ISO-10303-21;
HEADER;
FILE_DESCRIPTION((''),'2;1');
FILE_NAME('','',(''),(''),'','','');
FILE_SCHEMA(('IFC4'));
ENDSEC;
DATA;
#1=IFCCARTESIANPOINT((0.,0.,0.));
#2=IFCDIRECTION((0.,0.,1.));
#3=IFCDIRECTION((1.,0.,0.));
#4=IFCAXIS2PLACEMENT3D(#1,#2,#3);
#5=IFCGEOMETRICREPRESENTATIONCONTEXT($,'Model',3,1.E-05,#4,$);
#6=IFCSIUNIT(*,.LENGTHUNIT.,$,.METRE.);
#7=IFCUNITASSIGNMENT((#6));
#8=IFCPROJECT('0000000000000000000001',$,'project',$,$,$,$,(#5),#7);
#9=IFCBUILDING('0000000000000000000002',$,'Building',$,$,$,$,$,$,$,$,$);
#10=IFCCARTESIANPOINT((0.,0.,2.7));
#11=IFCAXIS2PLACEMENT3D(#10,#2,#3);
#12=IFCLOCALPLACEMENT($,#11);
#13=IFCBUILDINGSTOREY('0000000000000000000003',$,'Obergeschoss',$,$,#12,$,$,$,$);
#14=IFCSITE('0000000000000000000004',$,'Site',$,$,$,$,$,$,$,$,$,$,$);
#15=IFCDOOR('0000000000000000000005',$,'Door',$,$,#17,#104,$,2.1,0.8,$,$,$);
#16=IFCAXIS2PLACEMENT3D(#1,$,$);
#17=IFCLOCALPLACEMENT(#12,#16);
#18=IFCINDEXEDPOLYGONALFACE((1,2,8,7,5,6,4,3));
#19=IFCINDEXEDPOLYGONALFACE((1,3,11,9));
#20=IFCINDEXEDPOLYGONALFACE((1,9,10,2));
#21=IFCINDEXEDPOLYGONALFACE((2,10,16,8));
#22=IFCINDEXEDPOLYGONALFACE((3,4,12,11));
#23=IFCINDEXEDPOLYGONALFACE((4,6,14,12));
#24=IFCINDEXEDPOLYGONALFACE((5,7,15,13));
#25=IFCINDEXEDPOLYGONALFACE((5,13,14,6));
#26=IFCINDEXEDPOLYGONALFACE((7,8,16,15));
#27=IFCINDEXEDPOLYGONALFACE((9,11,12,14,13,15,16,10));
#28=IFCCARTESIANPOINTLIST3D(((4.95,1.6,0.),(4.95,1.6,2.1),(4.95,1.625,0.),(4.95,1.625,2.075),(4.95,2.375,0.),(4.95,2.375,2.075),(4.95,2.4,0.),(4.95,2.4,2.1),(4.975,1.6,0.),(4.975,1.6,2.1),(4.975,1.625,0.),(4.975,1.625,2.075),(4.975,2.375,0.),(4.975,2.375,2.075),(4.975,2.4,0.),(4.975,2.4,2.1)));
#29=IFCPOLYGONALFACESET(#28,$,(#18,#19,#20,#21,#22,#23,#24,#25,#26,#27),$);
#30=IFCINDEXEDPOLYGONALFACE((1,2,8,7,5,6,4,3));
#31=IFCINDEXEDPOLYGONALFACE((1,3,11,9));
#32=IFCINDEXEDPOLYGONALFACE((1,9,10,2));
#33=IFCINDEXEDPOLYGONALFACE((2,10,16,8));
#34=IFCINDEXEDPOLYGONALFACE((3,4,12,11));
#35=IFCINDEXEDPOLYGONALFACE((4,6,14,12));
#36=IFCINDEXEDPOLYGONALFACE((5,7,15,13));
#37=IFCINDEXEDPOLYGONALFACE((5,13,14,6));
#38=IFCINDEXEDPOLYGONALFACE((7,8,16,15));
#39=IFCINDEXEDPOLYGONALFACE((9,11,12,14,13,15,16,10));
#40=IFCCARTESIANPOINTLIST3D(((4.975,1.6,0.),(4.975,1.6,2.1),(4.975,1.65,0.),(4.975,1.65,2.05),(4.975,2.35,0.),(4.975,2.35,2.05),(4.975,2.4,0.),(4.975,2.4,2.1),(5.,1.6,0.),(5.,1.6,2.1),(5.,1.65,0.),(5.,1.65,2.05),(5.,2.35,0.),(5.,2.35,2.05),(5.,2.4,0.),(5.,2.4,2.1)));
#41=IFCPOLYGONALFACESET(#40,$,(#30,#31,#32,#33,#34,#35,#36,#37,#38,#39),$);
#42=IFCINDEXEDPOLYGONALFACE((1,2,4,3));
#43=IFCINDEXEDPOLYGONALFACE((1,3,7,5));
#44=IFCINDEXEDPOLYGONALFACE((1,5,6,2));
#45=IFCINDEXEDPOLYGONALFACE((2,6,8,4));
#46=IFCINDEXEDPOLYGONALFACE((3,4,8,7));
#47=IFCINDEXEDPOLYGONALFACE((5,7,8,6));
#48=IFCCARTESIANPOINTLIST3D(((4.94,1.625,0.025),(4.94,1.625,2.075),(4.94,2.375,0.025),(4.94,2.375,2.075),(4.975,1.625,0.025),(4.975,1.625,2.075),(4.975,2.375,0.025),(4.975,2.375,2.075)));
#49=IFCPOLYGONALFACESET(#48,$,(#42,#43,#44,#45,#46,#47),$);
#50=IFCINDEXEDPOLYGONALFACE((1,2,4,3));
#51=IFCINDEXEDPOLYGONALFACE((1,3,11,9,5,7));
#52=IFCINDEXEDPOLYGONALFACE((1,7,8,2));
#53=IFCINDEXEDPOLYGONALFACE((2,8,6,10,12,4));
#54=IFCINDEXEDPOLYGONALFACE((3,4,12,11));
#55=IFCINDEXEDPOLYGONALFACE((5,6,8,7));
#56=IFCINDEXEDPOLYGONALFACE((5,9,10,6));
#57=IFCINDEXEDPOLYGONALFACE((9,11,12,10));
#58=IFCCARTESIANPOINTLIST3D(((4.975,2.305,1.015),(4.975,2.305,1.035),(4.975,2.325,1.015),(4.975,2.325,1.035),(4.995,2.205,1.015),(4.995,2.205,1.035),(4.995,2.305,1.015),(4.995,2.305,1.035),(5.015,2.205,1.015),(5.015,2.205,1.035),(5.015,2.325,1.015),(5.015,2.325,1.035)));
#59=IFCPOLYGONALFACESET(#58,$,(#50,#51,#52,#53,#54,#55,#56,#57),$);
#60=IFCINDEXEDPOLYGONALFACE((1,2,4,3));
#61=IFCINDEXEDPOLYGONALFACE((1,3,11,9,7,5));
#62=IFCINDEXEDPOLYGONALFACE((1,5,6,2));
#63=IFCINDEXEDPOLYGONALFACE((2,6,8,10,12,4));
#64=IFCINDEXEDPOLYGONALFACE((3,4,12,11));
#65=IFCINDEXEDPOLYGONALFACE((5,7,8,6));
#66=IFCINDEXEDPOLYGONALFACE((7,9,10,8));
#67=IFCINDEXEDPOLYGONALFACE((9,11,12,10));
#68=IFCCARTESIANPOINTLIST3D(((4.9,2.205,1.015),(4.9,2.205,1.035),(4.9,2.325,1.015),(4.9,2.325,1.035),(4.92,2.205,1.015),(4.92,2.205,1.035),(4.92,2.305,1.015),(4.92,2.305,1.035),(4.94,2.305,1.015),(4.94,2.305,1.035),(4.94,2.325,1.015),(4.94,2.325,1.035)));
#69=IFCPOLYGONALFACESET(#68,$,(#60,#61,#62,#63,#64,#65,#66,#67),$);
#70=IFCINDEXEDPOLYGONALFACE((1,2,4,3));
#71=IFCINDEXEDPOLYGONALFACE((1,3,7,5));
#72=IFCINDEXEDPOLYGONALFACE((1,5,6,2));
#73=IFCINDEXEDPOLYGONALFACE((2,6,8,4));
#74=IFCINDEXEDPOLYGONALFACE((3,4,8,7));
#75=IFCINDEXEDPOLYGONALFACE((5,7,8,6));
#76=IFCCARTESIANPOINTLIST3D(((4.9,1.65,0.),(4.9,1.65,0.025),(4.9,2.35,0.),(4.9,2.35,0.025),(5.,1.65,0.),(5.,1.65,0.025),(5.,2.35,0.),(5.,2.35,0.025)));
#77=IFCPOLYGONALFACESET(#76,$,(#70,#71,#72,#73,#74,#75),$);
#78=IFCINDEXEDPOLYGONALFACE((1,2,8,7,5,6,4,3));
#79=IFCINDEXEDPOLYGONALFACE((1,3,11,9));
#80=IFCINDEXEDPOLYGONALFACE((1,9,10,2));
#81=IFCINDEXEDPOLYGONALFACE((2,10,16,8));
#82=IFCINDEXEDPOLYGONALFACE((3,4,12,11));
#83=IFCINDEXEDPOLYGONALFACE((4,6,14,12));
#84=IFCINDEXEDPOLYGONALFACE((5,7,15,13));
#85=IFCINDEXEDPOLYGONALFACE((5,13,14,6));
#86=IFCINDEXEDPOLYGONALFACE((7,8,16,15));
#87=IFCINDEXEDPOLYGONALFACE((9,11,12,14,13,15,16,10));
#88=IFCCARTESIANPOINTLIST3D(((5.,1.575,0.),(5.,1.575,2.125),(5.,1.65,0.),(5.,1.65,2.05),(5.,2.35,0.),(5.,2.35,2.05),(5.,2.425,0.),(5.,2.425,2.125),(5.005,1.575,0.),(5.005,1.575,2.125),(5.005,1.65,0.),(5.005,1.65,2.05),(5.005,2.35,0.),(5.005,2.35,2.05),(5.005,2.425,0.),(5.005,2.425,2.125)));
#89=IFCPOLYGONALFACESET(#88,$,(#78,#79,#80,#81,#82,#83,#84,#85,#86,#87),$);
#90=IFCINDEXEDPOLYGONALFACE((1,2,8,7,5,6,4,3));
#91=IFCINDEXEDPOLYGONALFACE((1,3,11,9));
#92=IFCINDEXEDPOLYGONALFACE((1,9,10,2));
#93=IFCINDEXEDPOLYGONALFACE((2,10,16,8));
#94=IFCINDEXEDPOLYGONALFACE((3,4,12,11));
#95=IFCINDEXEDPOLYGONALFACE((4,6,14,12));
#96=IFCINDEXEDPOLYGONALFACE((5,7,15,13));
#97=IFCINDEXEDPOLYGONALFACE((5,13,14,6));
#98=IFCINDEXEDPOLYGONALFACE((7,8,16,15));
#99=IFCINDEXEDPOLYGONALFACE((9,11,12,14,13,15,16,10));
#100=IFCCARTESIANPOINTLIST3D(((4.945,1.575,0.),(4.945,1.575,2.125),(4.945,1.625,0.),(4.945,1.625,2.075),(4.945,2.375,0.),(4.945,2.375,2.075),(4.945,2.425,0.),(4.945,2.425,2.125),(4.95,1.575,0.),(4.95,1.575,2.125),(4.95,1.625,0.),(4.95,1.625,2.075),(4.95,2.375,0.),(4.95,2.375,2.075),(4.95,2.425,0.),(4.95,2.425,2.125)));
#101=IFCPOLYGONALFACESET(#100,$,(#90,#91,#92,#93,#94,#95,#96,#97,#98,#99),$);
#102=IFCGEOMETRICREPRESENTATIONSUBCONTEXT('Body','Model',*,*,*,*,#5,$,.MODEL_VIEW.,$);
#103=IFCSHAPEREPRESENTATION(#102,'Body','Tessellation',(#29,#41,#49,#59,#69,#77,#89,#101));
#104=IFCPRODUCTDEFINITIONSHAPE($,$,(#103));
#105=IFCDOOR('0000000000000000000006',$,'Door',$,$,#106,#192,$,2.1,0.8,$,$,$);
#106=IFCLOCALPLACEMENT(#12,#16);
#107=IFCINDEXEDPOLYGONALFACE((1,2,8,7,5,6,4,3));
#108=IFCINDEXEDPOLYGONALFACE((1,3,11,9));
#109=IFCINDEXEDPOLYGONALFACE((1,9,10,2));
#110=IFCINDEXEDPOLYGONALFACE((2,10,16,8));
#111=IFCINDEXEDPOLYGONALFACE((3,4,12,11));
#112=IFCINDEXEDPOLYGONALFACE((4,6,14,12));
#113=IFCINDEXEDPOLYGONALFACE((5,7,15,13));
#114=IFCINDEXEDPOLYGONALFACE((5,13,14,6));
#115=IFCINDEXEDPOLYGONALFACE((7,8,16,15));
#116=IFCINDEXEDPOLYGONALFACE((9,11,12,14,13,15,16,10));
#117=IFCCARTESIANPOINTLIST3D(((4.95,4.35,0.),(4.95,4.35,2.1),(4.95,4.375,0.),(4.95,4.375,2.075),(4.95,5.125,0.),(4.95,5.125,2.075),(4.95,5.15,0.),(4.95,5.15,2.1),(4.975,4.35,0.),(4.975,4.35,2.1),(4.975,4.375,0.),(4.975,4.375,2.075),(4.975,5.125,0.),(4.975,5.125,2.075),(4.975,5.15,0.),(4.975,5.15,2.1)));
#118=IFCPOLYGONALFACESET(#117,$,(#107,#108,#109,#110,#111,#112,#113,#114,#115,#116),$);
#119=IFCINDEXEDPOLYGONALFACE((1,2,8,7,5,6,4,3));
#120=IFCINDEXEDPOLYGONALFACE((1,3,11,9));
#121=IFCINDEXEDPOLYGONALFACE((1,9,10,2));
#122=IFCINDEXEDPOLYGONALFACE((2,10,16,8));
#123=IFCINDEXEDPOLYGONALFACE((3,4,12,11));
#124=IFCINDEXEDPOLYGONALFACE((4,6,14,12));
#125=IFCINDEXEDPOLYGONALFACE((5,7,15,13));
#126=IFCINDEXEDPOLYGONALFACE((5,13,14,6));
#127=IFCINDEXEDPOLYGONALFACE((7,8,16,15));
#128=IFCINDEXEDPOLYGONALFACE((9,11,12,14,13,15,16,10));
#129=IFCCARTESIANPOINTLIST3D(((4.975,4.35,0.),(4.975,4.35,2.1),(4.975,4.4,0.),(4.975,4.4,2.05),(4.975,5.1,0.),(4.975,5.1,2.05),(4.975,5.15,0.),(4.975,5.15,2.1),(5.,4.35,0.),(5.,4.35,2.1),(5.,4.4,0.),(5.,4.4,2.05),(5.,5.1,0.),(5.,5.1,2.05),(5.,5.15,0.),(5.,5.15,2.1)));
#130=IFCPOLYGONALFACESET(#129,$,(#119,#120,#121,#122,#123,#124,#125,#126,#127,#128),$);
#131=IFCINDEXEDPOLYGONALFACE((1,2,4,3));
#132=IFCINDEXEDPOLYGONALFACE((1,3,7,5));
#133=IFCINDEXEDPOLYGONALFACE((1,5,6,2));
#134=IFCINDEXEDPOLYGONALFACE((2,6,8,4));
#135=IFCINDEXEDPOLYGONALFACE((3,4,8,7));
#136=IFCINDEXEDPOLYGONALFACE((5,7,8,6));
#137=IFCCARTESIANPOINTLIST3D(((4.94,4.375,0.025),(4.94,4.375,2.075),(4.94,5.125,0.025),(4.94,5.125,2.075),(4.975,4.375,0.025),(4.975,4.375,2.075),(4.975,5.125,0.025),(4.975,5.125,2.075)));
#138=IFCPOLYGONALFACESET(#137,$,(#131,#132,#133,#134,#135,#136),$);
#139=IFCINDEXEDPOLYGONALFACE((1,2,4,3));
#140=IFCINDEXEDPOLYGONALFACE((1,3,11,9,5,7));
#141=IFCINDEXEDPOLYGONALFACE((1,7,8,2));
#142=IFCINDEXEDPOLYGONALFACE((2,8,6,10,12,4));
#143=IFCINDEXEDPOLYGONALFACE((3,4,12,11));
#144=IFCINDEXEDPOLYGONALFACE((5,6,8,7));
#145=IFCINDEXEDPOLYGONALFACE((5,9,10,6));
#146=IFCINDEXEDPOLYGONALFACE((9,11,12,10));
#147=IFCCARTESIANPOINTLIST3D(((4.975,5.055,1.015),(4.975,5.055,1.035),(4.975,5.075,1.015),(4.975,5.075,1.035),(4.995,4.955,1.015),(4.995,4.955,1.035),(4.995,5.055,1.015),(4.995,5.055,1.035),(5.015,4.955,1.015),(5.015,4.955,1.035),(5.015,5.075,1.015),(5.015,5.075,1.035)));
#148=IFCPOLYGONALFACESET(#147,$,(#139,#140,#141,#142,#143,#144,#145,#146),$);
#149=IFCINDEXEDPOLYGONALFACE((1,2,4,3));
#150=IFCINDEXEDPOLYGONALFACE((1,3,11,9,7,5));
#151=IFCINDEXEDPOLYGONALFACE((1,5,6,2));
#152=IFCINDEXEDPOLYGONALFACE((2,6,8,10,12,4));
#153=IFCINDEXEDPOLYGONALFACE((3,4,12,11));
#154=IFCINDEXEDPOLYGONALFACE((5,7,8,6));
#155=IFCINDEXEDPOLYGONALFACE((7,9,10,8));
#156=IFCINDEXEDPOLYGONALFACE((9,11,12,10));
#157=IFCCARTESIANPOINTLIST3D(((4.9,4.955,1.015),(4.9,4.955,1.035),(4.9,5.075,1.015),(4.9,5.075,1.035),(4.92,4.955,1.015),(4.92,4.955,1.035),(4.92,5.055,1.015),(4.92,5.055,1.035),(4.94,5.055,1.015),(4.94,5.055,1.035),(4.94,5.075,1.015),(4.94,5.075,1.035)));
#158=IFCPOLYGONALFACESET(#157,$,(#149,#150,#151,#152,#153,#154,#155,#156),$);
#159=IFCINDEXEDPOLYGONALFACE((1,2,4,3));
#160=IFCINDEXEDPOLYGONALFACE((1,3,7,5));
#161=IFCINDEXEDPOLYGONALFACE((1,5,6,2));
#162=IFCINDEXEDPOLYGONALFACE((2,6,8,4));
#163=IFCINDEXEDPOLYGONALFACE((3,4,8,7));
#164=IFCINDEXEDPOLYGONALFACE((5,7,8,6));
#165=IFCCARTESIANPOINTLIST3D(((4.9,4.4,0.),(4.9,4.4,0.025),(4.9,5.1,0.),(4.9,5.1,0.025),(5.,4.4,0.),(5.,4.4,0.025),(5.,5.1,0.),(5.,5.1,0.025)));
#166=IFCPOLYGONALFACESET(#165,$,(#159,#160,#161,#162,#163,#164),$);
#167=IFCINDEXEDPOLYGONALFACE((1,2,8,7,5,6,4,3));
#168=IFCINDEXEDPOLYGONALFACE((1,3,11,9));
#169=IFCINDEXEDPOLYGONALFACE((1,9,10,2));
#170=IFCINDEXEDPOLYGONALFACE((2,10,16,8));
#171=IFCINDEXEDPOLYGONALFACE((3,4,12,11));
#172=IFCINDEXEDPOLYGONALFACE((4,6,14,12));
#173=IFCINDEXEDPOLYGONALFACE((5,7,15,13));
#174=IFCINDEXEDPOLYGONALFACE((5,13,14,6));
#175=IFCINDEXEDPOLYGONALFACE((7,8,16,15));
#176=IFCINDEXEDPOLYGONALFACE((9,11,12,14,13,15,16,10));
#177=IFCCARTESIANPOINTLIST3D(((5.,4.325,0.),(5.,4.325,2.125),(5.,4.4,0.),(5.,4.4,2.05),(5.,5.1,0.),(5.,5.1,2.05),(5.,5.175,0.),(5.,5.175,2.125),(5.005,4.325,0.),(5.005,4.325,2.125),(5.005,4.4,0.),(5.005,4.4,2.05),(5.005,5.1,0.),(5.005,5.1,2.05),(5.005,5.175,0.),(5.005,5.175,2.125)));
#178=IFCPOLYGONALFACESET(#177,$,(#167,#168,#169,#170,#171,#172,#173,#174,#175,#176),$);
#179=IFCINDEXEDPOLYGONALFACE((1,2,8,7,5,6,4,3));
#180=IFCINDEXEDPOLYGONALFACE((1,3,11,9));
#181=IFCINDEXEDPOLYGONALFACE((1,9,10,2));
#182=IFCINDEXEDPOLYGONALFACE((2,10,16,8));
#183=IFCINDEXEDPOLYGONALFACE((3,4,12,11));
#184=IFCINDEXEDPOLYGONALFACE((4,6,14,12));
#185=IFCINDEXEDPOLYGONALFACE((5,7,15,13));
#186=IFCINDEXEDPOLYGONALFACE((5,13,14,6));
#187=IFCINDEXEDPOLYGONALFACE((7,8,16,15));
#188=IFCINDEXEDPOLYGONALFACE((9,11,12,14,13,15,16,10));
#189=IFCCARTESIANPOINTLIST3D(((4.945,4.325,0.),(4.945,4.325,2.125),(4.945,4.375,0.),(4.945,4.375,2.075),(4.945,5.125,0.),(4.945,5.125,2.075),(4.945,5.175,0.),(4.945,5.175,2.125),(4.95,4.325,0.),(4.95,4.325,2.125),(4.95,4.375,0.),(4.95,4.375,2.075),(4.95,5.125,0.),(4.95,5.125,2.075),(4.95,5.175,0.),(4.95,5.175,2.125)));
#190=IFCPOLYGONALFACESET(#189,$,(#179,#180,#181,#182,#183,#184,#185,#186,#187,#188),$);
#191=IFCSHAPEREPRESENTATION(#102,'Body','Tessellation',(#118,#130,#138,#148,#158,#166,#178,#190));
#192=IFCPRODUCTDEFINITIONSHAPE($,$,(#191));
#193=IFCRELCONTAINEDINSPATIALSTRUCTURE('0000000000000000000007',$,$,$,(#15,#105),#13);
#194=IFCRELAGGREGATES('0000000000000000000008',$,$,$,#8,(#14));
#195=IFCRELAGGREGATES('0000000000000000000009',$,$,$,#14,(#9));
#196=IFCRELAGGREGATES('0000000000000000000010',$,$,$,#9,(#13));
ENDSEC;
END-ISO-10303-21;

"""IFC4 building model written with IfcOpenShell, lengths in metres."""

from ifc_helpers import new_model, si_unit, frame, origin_with_axes, place, context, subcontext, project, spatial, line, indexed_curve, outline, extrude, element, save


model = new_model("IFC4")

# Units and contexts
model_context = context("Model", 3, precision=1e-05, world=origin_with_axes())
body_context = subcontext(model_context, "Body", "Model", "MODEL_VIEW")
ifc_project = project(units=[si_unit("LENGTHUNIT", "METRE")], contexts=[model_context])

# Site, building, storey
site = spatial("IfcSite", under=ifc_project, Name="Site")
building = spatial("IfcBuilding", under=site, Name="Building")
storey_placement = place(None, frame((0.0, 0.0, 2.7), z_axis=(0.0, 0.0, 1.0), x_axis=(1.0, 0.0, 0.0)))
storey = spatial("IfcBuildingStorey", under=building, at=storey_placement, Name="Obergeschoss")

# Doors
door_1_placement = place(storey_placement, frame((5.0, 1.6, 0.0), z_axis=(0.0, 0.0, 1.0), x_axis=(0.0, 1.0, 0.0)))
element("IfcDoor", 1, at=door_1_placement, inside=storey, Name="Door", OverallHeight=2.1, OverallWidth=0.8, context=body_context, shape_type="SweptSolid", body=[
    extrude(outline(indexed_curve([(0.0, 0.0), (0.0, 2.1), (0.8, 2.1), (0.8, 0.0), (0.775, 0.0), (0.775, 2.075), (0.025, 2.075), (0.025, 0.0)], segments=[line(1, 2, 3, 4, 5, 6, 7, 8, 1)])), frame((0.0, 0.025, 0.0), z_axis=(0.0, -1.0, 0.0), x_axis=(1.0, 0.0, 0.0)), (0.0, 0.0, -1.0), 0.025),
    extrude(outline(indexed_curve([(0.0, 0.0), (0.0, 2.1), (0.8, 2.1), (0.8, 0.0), (0.75, 0.0), (0.75, 2.05), (0.05, 2.05), (0.05, 0.0)], segments=[line(1, 2, 3, 4, 5, 6, 7, 8, 1)])), frame((0.0, 0.0, 0.0), z_axis=(0.0, -1.0, 0.0), x_axis=(1.0, 0.0, 0.0)), (0.0, 0.0, -1.0), 0.025),
    extrude(outline(indexed_curve([(0.0, 0.0), (0.75, 0.0), (0.75, 0.035), (0.0, 0.035)], segments=[line(1, 2, 3, 4, 1)])), frame((0.025, 0.025, 0.025), z_axis=(0.0, 0.0, 1.0), x_axis=(1.0, 0.0, 0.0)), (0.0, 0.0, 1.0), 2.05),
    extrude(outline(indexed_curve([(0.0, 0.0), (0.0, -0.04), (-0.12, -0.04), (-0.12, -0.02), (-0.02, -0.02), (-0.02, 0.0)], segments=[line(1, 2, 3, 4, 5, 6, 1)])), frame((0.725, 0.025, 1.015), z_axis=(0.0, 0.0, 1.0), x_axis=(1.0, 0.0, 0.0)), (0.0, 0.0, 1.0), 0.02),
    extrude(outline(indexed_curve([(0.0, 0.0), (0.0, 0.04), (-0.12, 0.04), (-0.12, 0.02), (-0.02, 0.02), (-0.02, 0.0)], segments=[line(1, 2, 3, 4, 5, 6, 1)])), frame((0.725, 0.06, 1.015), z_axis=(0.0, 0.0, 1.0), x_axis=(1.0, 0.0, 0.0)), (0.0, 0.0, 1.0), 0.02),
    extrude(outline(indexed_curve([(0.0, 0.0), (0.7, 0.0), (0.7, 0.1), (0.0, 0.1)], segments=[line(1, 2, 3, 4, 1)])), frame((0.05, 0.0, 0.0), z_axis=(0.0, 0.0, 1.0), x_axis=(1.0, 0.0, 0.0)), (0.0, 0.0, 1.0), 0.025),
    extrude(outline(indexed_curve([(0.0, 0.0), (0.0, 2.125), (0.85, 2.125), (0.85, 0.0), (0.775, 0.0), (0.775, 2.05), (0.075, 2.05), (0.075, 0.0)], segments=[line(1, 2, 3, 4, 5, 6, 7, 8, 1)])), frame((-0.025, -0.005, 0.0), z_axis=(0.0, -1.0, 0.0), x_axis=(1.0, 0.0, 0.0)), (0.0, 0.0, -1.0), 0.005),
    extrude(outline(indexed_curve([(0.0, 0.0), (0.0, 2.125), (0.85, 2.125), (0.85, 0.0), (0.8, 0.0), (0.8, 2.075), (0.05, 2.075), (0.05, 0.0)], segments=[line(1, 2, 3, 4, 5, 6, 7, 8, 1)])), frame((-0.025, 0.05, 0.0), z_axis=(0.0, -1.0, 0.0), x_axis=(1.0, 0.0, 0.0)), (0.0, 0.0, -1.0), 0.005),
])
door_2_placement = place(storey_placement, frame((5.0, 4.35, 0.0), z_axis=(0.0, 0.0, 1.0), x_axis=(0.0, 1.0, 0.0)))
element("IfcDoor", 2, at=door_2_placement, inside=storey, Name="Door", OverallHeight=2.1, OverallWidth=0.8, context=body_context, shape_type="SweptSolid", body=[
    extrude(outline(indexed_curve([(0.0, 0.0), (0.0, 2.1), (0.8, 2.1), (0.8, 0.0), (0.775, 0.0), (0.775, 2.075), (0.025, 2.075), (0.025, 0.0)], segments=[line(1, 2, 3, 4, 5, 6, 7, 8, 1)])), frame((0.0, 0.025, 0.0), z_axis=(0.0, -1.0, 0.0), x_axis=(1.0, 0.0, 0.0)), (0.0, 0.0, -1.0), 0.025),
    extrude(outline(indexed_curve([(0.0, 0.0), (0.0, 2.1), (0.8, 2.1), (0.8, 0.0), (0.75, 0.0), (0.75, 2.05), (0.05, 2.05), (0.05, 0.0)], segments=[line(1, 2, 3, 4, 5, 6, 7, 8, 1)])), frame((0.0, 0.0, 0.0), z_axis=(0.0, -1.0, 0.0), x_axis=(1.0, 0.0, 0.0)), (0.0, 0.0, -1.0), 0.025),
    extrude(outline(indexed_curve([(0.0, 0.0), (0.75, 0.0), (0.75, 0.035), (0.0, 0.035)], segments=[line(1, 2, 3, 4, 1)])), frame((0.025, 0.025, 0.025), z_axis=(0.0, 0.0, 1.0), x_axis=(1.0, 0.0, 0.0)), (0.0, 0.0, 1.0), 2.05),
    extrude(outline(indexed_curve([(0.0, 0.0), (0.0, -0.04), (-0.12, -0.04), (-0.12, -0.02), (-0.02, -0.02), (-0.02, 0.0)], segments=[line(1, 2, 3, 4, 5, 6, 1)])), frame((0.725, 0.025, 1.015), z_axis=(0.0, 0.0, 1.0), x_axis=(1.0, 0.0, 0.0)), (0.0, 0.0, 1.0), 0.02),
    extrude(outline(indexed_curve([(0.0, 0.0), (0.0, 0.04), (-0.12, 0.04), (-0.12, 0.02), (-0.02, 0.02), (-0.02, 0.0)], segments=[line(1, 2, 3, 4, 5, 6, 1)])), frame((0.725, 0.06, 1.015), z_axis=(0.0, 0.0, 1.0), x_axis=(1.0, 0.0, 0.0)), (0.0, 0.0, 1.0), 0.02),
    extrude(outline(indexed_curve([(0.0, 0.0), (0.7, 0.0), (0.7, 0.1), (0.0, 0.1)], segments=[line(1, 2, 3, 4, 1)])), frame((0.05, 0.0, 0.0), z_axis=(0.0, 0.0, 1.0), x_axis=(1.0, 0.0, 0.0)), (0.0, 0.0, 1.0), 0.025),
    extrude(outline(indexed_curve([(0.0, 0.0), (0.0, 2.125), (0.85, 2.125), (0.85, 0.0), (0.775, 0.0), (0.775, 2.05), (0.075, 2.05), (0.075, 0.0)], segments=[line(1, 2, 3, 4, 5, 6, 7, 8, 1)])), frame((-0.025, -0.005, 0.0), z_axis=(0.0, -1.0, 0.0), x_axis=(1.0, 0.0, 0.0)), (0.0, 0.0, -1.0), 0.005),
    extrude(outline(indexed_curve([(0.0, 0.0), (0.0, 2.125), (0.85, 2.125), (0.85, 0.0), (0.8, 0.0), (0.8, 2.075), (0.05, 2.075), (0.05, 0.0)], segments=[line(1, 2, 3, 4, 5, 6, 7, 8, 1)])), frame((-0.025, 0.05, 0.0), z_axis=(0.0, -1.0, 0.0), x_axis=(1.0, 0.0, 0.0)), (0.0, 0.0, -1.0), 0.005),
])

save(model, "model.ifc")
